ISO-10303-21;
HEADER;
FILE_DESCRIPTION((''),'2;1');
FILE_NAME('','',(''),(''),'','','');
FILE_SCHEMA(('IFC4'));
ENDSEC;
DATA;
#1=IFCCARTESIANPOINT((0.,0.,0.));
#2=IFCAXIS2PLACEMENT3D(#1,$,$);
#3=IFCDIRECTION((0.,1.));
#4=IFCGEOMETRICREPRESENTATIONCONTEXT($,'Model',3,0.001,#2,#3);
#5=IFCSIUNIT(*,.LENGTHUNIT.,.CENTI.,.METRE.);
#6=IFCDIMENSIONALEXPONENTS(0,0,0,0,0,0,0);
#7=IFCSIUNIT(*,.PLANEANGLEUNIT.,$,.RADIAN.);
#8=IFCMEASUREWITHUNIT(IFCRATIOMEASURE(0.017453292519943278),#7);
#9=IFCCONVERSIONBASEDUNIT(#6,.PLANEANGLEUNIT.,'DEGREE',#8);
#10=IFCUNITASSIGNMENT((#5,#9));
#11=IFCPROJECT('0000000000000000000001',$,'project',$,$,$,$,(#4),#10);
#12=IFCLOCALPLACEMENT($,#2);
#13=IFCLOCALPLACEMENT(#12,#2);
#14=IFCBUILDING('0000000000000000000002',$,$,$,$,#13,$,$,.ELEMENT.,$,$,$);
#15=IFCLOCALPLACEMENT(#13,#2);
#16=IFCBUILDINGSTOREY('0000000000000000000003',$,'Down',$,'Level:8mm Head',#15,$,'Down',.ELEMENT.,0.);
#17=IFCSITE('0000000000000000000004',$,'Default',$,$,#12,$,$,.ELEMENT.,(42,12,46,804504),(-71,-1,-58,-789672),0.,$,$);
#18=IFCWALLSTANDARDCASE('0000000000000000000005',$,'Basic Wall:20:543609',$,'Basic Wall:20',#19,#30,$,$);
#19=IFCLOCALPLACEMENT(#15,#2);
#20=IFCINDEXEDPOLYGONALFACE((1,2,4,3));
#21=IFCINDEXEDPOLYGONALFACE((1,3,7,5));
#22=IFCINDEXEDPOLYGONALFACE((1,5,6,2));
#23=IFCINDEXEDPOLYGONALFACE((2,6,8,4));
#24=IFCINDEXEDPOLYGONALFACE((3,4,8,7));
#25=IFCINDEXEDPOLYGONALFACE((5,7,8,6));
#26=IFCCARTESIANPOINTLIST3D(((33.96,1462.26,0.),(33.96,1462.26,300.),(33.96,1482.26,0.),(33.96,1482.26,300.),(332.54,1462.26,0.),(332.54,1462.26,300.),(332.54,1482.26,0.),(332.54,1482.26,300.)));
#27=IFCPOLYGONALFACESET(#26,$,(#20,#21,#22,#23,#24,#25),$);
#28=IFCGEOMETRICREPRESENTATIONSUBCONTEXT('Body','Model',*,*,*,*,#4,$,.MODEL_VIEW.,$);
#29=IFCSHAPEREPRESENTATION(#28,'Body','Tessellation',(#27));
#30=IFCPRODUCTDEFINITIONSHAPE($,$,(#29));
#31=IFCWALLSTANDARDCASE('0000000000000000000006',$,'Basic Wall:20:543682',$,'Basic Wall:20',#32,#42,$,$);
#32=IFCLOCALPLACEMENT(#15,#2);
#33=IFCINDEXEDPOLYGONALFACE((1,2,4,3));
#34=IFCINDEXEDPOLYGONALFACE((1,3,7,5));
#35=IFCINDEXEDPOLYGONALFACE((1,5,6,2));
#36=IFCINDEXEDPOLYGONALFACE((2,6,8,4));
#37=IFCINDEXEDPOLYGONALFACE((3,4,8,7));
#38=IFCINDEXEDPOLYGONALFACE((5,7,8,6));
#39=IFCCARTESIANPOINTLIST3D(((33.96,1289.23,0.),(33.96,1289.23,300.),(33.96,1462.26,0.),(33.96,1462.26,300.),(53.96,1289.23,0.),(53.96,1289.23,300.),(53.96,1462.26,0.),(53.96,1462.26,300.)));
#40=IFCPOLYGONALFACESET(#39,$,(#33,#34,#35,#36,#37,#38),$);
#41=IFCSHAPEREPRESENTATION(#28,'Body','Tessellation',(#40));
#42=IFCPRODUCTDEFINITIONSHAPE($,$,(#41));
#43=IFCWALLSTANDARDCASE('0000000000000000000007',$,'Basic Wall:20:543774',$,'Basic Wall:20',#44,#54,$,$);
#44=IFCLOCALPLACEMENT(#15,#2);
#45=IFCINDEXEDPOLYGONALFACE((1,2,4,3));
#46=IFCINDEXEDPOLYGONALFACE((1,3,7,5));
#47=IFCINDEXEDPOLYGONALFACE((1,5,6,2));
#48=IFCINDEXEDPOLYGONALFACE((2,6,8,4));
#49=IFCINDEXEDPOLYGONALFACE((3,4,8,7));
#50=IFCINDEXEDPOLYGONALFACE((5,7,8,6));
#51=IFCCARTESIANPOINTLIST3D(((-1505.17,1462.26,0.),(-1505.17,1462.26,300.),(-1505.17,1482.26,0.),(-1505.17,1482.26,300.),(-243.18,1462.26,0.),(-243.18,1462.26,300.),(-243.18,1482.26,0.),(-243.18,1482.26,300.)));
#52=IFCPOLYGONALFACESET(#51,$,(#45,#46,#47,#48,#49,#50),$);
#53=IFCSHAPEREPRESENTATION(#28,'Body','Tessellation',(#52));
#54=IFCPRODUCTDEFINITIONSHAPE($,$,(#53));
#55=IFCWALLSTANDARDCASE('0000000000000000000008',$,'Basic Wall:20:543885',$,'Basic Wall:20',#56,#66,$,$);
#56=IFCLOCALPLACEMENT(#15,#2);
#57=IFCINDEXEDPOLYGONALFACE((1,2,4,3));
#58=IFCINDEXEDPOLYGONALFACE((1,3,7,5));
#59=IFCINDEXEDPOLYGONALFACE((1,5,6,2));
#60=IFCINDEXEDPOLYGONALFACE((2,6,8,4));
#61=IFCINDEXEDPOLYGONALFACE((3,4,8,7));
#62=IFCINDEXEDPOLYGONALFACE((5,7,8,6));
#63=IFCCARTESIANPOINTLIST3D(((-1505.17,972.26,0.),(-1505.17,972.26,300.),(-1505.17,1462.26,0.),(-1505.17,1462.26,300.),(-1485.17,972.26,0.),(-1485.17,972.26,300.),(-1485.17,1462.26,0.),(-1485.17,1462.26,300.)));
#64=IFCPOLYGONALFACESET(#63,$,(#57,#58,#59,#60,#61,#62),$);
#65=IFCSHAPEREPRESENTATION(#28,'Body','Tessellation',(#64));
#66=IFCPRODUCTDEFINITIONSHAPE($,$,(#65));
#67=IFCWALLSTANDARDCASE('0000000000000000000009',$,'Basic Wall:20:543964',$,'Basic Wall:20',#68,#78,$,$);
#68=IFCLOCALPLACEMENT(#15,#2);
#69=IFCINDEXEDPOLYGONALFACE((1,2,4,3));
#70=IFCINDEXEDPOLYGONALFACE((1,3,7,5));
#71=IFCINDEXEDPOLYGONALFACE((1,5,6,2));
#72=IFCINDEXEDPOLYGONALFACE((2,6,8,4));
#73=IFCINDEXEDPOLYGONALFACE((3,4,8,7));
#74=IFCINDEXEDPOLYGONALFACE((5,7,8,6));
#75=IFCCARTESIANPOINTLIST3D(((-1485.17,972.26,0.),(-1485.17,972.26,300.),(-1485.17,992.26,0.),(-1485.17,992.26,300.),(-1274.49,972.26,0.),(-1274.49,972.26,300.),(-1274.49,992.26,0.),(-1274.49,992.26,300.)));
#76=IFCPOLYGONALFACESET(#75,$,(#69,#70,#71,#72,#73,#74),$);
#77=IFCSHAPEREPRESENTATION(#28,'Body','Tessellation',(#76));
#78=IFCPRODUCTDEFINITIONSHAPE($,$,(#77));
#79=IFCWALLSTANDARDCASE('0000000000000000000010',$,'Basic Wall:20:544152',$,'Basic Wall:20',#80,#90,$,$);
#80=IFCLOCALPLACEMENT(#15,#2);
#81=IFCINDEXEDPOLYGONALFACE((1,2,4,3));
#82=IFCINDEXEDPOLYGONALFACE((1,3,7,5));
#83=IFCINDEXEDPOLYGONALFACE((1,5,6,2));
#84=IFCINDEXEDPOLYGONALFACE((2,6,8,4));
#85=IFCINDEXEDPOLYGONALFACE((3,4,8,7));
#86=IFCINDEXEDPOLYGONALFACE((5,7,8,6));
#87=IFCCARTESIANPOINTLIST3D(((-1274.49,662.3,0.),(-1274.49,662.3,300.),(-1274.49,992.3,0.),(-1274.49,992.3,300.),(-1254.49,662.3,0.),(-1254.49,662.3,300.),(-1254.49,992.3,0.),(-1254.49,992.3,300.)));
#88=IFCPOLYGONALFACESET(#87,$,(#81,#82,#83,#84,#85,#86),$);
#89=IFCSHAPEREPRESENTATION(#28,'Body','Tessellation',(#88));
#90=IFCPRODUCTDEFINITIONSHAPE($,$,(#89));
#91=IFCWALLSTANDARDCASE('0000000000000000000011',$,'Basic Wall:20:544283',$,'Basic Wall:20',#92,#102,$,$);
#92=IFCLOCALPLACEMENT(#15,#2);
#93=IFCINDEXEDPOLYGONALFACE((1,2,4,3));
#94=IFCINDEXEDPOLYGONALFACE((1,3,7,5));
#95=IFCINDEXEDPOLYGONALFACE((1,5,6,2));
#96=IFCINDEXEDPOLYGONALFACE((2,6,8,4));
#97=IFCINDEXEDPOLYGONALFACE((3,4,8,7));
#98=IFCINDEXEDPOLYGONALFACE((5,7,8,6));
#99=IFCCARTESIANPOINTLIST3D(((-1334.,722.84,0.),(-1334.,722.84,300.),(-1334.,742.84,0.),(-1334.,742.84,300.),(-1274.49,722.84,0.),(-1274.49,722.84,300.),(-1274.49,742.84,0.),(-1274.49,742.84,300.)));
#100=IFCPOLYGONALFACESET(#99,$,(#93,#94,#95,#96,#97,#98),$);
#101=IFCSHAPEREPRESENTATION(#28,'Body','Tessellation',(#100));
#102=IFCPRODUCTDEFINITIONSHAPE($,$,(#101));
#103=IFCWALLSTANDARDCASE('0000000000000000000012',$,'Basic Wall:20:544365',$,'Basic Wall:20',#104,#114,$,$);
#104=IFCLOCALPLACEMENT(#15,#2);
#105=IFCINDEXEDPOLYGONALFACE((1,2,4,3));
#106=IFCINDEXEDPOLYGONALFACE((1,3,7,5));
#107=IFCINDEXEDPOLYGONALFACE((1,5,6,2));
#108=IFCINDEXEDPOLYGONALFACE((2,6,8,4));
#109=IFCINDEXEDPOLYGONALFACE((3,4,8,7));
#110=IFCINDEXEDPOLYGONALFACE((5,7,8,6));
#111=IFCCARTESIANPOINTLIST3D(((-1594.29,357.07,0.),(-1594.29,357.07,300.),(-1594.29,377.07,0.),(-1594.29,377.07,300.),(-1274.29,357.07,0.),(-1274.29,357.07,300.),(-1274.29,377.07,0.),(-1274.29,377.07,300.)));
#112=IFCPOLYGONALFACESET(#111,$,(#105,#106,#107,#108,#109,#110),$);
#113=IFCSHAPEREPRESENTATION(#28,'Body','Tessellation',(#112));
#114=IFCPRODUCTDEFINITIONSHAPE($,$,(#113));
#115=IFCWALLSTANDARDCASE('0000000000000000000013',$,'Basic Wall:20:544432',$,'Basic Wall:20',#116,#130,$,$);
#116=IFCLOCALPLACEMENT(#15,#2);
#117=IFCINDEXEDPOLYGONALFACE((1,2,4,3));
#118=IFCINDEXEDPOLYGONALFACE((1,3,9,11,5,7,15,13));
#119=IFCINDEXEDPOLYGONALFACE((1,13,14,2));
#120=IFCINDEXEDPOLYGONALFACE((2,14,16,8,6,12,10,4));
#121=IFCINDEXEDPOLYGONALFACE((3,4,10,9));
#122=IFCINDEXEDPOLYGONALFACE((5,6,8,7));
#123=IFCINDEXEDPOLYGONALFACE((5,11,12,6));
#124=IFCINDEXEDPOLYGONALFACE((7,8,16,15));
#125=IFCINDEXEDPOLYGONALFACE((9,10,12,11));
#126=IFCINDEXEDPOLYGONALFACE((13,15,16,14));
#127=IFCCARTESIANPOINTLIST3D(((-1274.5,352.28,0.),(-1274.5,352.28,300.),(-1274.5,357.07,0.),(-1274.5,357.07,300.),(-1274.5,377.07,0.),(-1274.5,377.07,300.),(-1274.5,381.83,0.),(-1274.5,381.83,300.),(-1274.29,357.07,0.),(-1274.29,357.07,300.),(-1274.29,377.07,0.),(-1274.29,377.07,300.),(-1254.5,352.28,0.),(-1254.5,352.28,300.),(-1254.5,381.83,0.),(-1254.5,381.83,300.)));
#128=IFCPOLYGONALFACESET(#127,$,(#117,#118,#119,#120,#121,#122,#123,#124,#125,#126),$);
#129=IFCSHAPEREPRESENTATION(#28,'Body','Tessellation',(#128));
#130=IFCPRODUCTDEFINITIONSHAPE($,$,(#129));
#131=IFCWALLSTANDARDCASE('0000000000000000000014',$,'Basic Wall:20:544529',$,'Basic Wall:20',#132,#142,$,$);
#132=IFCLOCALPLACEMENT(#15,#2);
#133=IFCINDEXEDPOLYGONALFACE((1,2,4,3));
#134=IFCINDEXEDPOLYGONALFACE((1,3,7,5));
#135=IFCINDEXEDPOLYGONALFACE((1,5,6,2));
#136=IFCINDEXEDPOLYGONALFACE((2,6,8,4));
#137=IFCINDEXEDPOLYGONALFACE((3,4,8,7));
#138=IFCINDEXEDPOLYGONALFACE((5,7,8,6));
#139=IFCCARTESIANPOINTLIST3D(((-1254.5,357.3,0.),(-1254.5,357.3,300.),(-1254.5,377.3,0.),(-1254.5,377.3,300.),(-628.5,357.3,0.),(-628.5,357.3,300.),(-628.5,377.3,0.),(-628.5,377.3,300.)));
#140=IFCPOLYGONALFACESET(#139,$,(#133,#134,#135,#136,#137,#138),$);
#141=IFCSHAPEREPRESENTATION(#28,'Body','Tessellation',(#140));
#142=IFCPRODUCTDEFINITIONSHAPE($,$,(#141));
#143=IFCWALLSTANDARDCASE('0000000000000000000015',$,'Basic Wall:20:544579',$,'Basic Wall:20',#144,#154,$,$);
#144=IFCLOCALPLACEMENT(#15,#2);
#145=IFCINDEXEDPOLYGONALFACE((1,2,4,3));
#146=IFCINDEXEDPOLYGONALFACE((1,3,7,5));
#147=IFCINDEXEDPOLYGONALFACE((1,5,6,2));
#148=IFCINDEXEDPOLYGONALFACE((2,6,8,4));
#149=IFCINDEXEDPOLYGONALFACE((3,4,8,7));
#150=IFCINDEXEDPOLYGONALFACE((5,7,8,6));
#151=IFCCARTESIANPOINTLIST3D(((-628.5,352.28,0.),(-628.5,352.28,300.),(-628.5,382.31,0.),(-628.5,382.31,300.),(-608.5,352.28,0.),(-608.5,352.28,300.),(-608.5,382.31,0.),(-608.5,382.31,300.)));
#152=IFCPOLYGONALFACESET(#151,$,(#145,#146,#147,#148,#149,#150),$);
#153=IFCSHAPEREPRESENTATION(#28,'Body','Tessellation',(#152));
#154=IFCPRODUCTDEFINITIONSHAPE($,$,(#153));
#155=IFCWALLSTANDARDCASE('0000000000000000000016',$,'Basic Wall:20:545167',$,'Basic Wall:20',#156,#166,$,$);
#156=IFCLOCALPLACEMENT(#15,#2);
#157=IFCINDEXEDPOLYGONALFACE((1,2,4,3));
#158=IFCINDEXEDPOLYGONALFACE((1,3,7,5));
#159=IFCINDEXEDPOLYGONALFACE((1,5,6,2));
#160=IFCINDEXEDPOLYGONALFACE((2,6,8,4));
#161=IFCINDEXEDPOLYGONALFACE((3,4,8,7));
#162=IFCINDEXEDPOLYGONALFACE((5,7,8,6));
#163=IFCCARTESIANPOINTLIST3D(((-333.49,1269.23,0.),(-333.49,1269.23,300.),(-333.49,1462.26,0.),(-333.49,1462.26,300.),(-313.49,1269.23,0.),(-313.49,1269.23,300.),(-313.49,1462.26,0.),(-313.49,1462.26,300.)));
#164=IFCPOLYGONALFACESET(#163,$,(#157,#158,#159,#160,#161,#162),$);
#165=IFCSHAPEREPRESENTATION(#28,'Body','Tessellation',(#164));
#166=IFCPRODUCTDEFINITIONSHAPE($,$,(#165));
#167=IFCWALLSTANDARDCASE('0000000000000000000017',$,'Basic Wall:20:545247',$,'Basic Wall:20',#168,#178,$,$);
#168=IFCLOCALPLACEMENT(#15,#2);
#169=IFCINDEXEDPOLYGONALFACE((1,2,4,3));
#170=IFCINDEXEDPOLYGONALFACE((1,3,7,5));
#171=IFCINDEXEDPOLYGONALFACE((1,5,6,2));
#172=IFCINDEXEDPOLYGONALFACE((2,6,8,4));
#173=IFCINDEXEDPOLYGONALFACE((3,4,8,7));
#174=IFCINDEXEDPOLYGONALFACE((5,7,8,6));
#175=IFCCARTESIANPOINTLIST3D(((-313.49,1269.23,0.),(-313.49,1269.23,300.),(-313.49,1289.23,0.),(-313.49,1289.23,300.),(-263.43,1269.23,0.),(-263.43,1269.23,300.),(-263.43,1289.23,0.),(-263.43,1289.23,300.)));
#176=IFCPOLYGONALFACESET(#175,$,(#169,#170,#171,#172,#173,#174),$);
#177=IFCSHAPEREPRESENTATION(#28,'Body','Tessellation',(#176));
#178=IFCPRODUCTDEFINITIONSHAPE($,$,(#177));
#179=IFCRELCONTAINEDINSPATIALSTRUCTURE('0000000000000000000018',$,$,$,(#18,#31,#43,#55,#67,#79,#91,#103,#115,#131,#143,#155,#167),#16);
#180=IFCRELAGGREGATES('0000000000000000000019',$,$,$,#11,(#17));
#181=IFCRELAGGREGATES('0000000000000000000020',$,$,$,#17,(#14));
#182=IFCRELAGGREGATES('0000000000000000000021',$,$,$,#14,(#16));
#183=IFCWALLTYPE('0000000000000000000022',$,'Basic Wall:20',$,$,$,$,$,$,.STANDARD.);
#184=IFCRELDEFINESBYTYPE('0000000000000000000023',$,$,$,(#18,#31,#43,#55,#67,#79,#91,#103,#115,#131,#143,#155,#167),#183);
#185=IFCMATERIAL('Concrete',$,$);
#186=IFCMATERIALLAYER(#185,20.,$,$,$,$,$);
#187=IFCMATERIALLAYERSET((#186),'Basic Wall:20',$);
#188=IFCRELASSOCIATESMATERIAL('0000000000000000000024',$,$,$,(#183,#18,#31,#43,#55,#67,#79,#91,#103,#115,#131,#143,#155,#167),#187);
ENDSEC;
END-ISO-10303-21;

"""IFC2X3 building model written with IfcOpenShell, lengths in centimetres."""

from ifc_helpers import new_model, entity, si_unit, converted_unit, direction, frame, frame_2d, origin, place, context, subcontext, project, spatial, polyline, rectangle, extrude, clip, bounded_halfspace, material, layer, layer_set, layer_usage, type_object, element, save


model = new_model("IFC2X3")

# Units and contexts
model_context = context("Model", 3, precision=0.001, world=origin(), true_north=direction((0.0, 1.0)))
body_context = subcontext(model_context, "Body", "Model", "MODEL_VIEW")
ifc_project = project(units=[si_unit("LENGTHUNIT", "METRE", prefix="CENTI"), converted_unit("PLANEANGLEUNIT", "DEGREE", entity("IfcRatioMeasure", 0.017453292519943278), si_unit("PLANEANGLEUNIT", "RADIAN"), dimensions=[0, 0, 0, 0, 0, 0, 0])], contexts=[model_context])

# Site, building, storey
site_placement = place(None, origin())
site = spatial("IfcSite", under=ifc_project, at=site_placement, Name="Default", CompositionType="ELEMENT", RefLatitude=(42, 12, 46, 804504), RefLongitude=(-71, -1, -58, -789672), RefElevation=0.0)
building_placement = place(site_placement, origin())
building = spatial("IfcBuilding", under=site, at=building_placement, CompositionType="ELEMENT")
storey_placement = place(building_placement, origin())
storey = spatial("IfcBuildingStorey", under=building, at=storey_placement, Name="Down", ObjectType="Level:8mm Head", LongName="Down", CompositionType="ELEMENT", Elevation=0.0)

# Walls
ifc_material = material(Name="Concrete")
ifc_layer_1 = layer(ifc_material, 20.0)
ifc_layer_set_1 = layer_set([ifc_layer_1], Name="Basic Wall:20")
ifc_layer_usage_1 = layer_usage(ifc_layer_set_1, "AXIS2", "POSITIVE", -10.0)
wall_type_1 = type_object("IfcWallType", Name="Basic Wall:20", PredefinedType="STANDARD", material=ifc_layer_set_1)
wall_1_placement = place(storey_placement, frame((332.54, 1472.26, 0.0), z_axis=(0.0, 0.0, 1.0), x_axis=(-1.0, 0.0, 0.0)))
element("IfcWallStandardCase", 1, at=wall_1_placement, inside=storey, type_object=wall_type_1, material=ifc_layer_usage_1, Name="Basic Wall:20:543609", ObjectType="Basic Wall:20", context=body_context, shape_type="SweptSolid", body=[
    extrude(rectangle(XDim=298.58, YDim=20.0, at=frame_2d((149.29, 0.0), x_axis=(-1.0, 0.0))), origin(), (0.0, 0.0, 1.0), 300.0),
])
ifc_layer_usage_2 = layer_usage(ifc_layer_set_1, "AXIS2", "POSITIVE", -10.0)
wall_2_placement = place(storey_placement, frame((43.96, 1462.26, 0.0), z_axis=(0.0, 0.0, 1.0), x_axis=(0.0, -1.0, 0.0)))
element("IfcWallStandardCase", 2, at=wall_2_placement, inside=storey, type_object=wall_type_1, material=ifc_layer_usage_2, Name="Basic Wall:20:543682", ObjectType="Basic Wall:20", context=body_context, shape_type="SweptSolid", body=[
    extrude(rectangle(XDim=173.03, YDim=20.0, at=frame_2d((86.52, 0.0), x_axis=(-1.0, 0.0))), origin(), (0.0, 0.0, 1.0), 300.0),
])
ifc_layer_usage_3 = layer_usage(ifc_layer_set_1, "AXIS2", "POSITIVE", -10.0)
wall_3_placement = place(storey_placement, frame((-243.18, 1472.26, 0.0), z_axis=(0.0, 0.0, 1.0), x_axis=(-1.0, 0.0, 0.0)))
element("IfcWallStandardCase", 3, at=wall_3_placement, inside=storey, type_object=wall_type_1, material=ifc_layer_usage_3, Name="Basic Wall:20:543774", ObjectType="Basic Wall:20", context=body_context, shape_type="SweptSolid", body=[
    extrude(rectangle(XDim=1261.99, YDim=20.0, at=frame_2d((631.0, 0.0), x_axis=(-1.0, 0.0))), origin(), (0.0, 0.0, 1.0), 300.0),
])
ifc_layer_usage_4 = layer_usage(ifc_layer_set_1, "AXIS2", "POSITIVE", -10.0)
wall_4_placement = place(storey_placement, frame((-1495.17, 1462.26, 0.0), z_axis=(0.0, 0.0, 1.0), x_axis=(0.0, -1.0, 0.0)))
element("IfcWallStandardCase", 4, at=wall_4_placement, inside=storey, type_object=wall_type_1, material=ifc_layer_usage_4, Name="Basic Wall:20:543885", ObjectType="Basic Wall:20", context=body_context, shape_type="SweptSolid", body=[
    extrude(rectangle(XDim=490.0, YDim=20.0, at=frame_2d((245.0, 0.0), x_axis=(-1.0, 0.0))), origin(), (0.0, 0.0, 1.0), 300.0),
])
ifc_layer_usage_5 = layer_usage(ifc_layer_set_1, "AXIS2", "POSITIVE", -10.0)
wall_5_placement = place(storey_placement, frame((-1485.17, 982.26, 0.0)))
element("IfcWallStandardCase", 5, at=wall_5_placement, inside=storey, type_object=wall_type_1, material=ifc_layer_usage_5, Name="Basic Wall:20:543964", ObjectType="Basic Wall:20", context=body_context, shape_type="Clipping", body=[
    clip(extrude(rectangle(XDim=210.68, YDim=20.0, at=frame_2d((105.34, 0.0), x_axis=(-1.0, 0.0))), origin(), (0.0, 0.0, 1.0), 300.0), bounded_halfspace(frame((210.68, -10.0, 300.0), z_axis=(-1.0, 0.0, 0.0), x_axis=(0.0, -1.0, 0.0)), True, frame((210.68, -10.0, 300.0), z_axis=(-1.0, 0.0, 0.0), x_axis=(0.0, -1.0, 0.0)), polyline([(0.0, 0.0), (-20.0, 0.0), (-20.0, -20.0), (-20.0, -300.0), (0.0, -300.0), (0.0, 0.0)]))),
])
ifc_layer_usage_6 = layer_usage(ifc_layer_set_1, "AXIS2", "NEGATIVE", 10.0)
wall_6_placement = place(storey_placement, frame((-1264.49, 992.3, 0.0), z_axis=(0.0, 0.0, 1.0), x_axis=(0.0, -1.0, 0.0)))
element("IfcWallStandardCase", 6, at=wall_6_placement, inside=storey, type_object=wall_type_1, material=ifc_layer_usage_6, Name="Basic Wall:20:544152", ObjectType="Basic Wall:20", context=body_context, shape_type="SweptSolid", body=[
    extrude(rectangle(XDim=330.0, YDim=20.0, at=frame_2d((165.0, 0.0), x_axis=(-1.0, 0.0))), origin(), (0.0, 0.0, 1.0), 300.0),
])
ifc_layer_usage_7 = layer_usage(ifc_layer_set_1, "AXIS2", "POSITIVE", -10.0)
wall_7_placement = place(storey_placement, frame((-1274.49, 732.84, 0.0), z_axis=(0.0, 0.0, 1.0), x_axis=(-1.0, 0.0, 0.0)))
element("IfcWallStandardCase", 7, at=wall_7_placement, inside=storey, type_object=wall_type_1, material=ifc_layer_usage_7, Name="Basic Wall:20:544283", ObjectType="Basic Wall:20", context=body_context, shape_type="SweptSolid", body=[
    extrude(rectangle(XDim=59.52, YDim=20.0, at=frame_2d((29.76, 0.0), x_axis=(-1.0, 0.0))), origin(), (0.0, 0.0, 1.0), 300.0),
])
ifc_layer_usage_8 = layer_usage(ifc_layer_set_1, "AXIS2", "NEGATIVE", 10.0)
wall_8_placement = place(storey_placement, frame((-1594.29, 367.07, 0.0)))
element("IfcWallStandardCase", 8, at=wall_8_placement, inside=storey, type_object=wall_type_1, material=ifc_layer_usage_8, Name="Basic Wall:20:544365", ObjectType="Basic Wall:20", context=body_context, shape_type="SweptSolid", body=[
    extrude(rectangle(XDim=320.0, YDim=20.0, at=frame_2d((160.0, 0.0), x_axis=(-1.0, 0.0))), origin(), (0.0, 0.0, 1.0), 300.0),
])
ifc_layer_usage_9 = layer_usage(ifc_layer_set_1, "AXIS2", "POSITIVE", -10.0)
wall_9_placement = place(storey_placement, frame((-1264.5, 381.83, 0.0), z_axis=(0.0, 0.0, 1.0), x_axis=(0.0, -1.0, 0.0)))
element("IfcWallStandardCase", 9, at=wall_9_placement, inside=storey, type_object=wall_type_1, material=ifc_layer_usage_9, Name="Basic Wall:20:544432", ObjectType="Basic Wall:20", context=body_context, shape_type="Clipping", body=[
    clip(extrude(rectangle(XDim=29.55, YDim=20.0, at=frame_2d((14.77, 0.0), x_axis=(-1.0, 0.0))), origin(), (0.0, 0.0, 1.0), 300.0), bounded_halfspace(frame((24.77, -9.79, 0.0), z_axis=(0.0, 1.0, 0.0), x_axis=(-1.0, 0.0, 0.0)), True, frame((24.77, -9.79, 0.0), z_axis=(0.0, 1.0, 0.0), x_axis=(-1.0, 0.0, 0.0)), polyline([(0.0, 0.0), (20.0, 0.0), (20.0, 300.0), (0.0, 300.0), (0.0, 0.0)]))),
])
ifc_layer_usage_10 = layer_usage(ifc_layer_set_1, "AXIS2", "NEGATIVE", 10.0)
wall_10_placement = place(storey_placement, frame((-1254.5, 367.3, 0.0)))
element("IfcWallStandardCase", 10, at=wall_10_placement, inside=storey, type_object=wall_type_1, material=ifc_layer_usage_10, Name="Basic Wall:20:544529", ObjectType="Basic Wall:20", context=body_context, shape_type="SweptSolid", body=[
    extrude(rectangle(XDim=626.01, YDim=20.0, at=frame_2d((313.0, 0.0), x_axis=(-1.0, 0.0))), origin(), (0.0, 0.0, 1.0), 300.0),
])
ifc_layer_usage_11 = layer_usage(ifc_layer_set_1, "AXIS2", "POSITIVE", -10.0)
wall_11_placement = place(storey_placement, frame((-618.5, 382.31, 0.0), z_axis=(0.0, 0.0, 1.0), x_axis=(0.0, -1.0, 0.0)))
element("IfcWallStandardCase", 11, at=wall_11_placement, inside=storey, type_object=wall_type_1, material=ifc_layer_usage_11, Name="Basic Wall:20:544579", ObjectType="Basic Wall:20", context=body_context, shape_type="SweptSolid", body=[
    extrude(rectangle(XDim=30.02, YDim=20.0, at=frame_2d((15.01, 0.0), x_axis=(-1.0, 0.0))), origin(), (0.0, 0.0, 1.0), 300.0),
])
ifc_layer_usage_12 = layer_usage(ifc_layer_set_1, "AXIS2", "NEGATIVE", 10.0)
wall_12_placement = place(storey_placement, frame((-323.49, 1269.23, 0.0), z_axis=(0.0, 0.0, 1.0), x_axis=(0.0, 1.0, 0.0)))
element("IfcWallStandardCase", 12, at=wall_12_placement, inside=storey, type_object=wall_type_1, material=ifc_layer_usage_12, Name="Basic Wall:20:545167", ObjectType="Basic Wall:20", context=body_context, shape_type="SweptSolid", body=[
    extrude(rectangle(XDim=193.03, YDim=20.0, at=frame_2d((96.52, 0.0), x_axis=(-1.0, 0.0))), origin(), (0.0, 0.0, 1.0), 300.0),
])
ifc_layer_usage_13 = layer_usage(ifc_layer_set_1, "AXIS2", "POSITIVE", -10.0)
wall_13_placement = place(storey_placement, frame((-313.49, 1279.23, 0.0)))
element("IfcWallStandardCase", 13, at=wall_13_placement, inside=storey, type_object=wall_type_1, material=ifc_layer_usage_13, Name="Basic Wall:20:545247", ObjectType="Basic Wall:20", context=body_context, shape_type="SweptSolid", body=[
    extrude(rectangle(XDim=50.06, YDim=20.0, at=frame_2d((25.03, 0.0), x_axis=(-1.0, 0.0))), origin(), (0.0, 0.0, 1.0), 300.0),
])

save(model, "model.ifc")
